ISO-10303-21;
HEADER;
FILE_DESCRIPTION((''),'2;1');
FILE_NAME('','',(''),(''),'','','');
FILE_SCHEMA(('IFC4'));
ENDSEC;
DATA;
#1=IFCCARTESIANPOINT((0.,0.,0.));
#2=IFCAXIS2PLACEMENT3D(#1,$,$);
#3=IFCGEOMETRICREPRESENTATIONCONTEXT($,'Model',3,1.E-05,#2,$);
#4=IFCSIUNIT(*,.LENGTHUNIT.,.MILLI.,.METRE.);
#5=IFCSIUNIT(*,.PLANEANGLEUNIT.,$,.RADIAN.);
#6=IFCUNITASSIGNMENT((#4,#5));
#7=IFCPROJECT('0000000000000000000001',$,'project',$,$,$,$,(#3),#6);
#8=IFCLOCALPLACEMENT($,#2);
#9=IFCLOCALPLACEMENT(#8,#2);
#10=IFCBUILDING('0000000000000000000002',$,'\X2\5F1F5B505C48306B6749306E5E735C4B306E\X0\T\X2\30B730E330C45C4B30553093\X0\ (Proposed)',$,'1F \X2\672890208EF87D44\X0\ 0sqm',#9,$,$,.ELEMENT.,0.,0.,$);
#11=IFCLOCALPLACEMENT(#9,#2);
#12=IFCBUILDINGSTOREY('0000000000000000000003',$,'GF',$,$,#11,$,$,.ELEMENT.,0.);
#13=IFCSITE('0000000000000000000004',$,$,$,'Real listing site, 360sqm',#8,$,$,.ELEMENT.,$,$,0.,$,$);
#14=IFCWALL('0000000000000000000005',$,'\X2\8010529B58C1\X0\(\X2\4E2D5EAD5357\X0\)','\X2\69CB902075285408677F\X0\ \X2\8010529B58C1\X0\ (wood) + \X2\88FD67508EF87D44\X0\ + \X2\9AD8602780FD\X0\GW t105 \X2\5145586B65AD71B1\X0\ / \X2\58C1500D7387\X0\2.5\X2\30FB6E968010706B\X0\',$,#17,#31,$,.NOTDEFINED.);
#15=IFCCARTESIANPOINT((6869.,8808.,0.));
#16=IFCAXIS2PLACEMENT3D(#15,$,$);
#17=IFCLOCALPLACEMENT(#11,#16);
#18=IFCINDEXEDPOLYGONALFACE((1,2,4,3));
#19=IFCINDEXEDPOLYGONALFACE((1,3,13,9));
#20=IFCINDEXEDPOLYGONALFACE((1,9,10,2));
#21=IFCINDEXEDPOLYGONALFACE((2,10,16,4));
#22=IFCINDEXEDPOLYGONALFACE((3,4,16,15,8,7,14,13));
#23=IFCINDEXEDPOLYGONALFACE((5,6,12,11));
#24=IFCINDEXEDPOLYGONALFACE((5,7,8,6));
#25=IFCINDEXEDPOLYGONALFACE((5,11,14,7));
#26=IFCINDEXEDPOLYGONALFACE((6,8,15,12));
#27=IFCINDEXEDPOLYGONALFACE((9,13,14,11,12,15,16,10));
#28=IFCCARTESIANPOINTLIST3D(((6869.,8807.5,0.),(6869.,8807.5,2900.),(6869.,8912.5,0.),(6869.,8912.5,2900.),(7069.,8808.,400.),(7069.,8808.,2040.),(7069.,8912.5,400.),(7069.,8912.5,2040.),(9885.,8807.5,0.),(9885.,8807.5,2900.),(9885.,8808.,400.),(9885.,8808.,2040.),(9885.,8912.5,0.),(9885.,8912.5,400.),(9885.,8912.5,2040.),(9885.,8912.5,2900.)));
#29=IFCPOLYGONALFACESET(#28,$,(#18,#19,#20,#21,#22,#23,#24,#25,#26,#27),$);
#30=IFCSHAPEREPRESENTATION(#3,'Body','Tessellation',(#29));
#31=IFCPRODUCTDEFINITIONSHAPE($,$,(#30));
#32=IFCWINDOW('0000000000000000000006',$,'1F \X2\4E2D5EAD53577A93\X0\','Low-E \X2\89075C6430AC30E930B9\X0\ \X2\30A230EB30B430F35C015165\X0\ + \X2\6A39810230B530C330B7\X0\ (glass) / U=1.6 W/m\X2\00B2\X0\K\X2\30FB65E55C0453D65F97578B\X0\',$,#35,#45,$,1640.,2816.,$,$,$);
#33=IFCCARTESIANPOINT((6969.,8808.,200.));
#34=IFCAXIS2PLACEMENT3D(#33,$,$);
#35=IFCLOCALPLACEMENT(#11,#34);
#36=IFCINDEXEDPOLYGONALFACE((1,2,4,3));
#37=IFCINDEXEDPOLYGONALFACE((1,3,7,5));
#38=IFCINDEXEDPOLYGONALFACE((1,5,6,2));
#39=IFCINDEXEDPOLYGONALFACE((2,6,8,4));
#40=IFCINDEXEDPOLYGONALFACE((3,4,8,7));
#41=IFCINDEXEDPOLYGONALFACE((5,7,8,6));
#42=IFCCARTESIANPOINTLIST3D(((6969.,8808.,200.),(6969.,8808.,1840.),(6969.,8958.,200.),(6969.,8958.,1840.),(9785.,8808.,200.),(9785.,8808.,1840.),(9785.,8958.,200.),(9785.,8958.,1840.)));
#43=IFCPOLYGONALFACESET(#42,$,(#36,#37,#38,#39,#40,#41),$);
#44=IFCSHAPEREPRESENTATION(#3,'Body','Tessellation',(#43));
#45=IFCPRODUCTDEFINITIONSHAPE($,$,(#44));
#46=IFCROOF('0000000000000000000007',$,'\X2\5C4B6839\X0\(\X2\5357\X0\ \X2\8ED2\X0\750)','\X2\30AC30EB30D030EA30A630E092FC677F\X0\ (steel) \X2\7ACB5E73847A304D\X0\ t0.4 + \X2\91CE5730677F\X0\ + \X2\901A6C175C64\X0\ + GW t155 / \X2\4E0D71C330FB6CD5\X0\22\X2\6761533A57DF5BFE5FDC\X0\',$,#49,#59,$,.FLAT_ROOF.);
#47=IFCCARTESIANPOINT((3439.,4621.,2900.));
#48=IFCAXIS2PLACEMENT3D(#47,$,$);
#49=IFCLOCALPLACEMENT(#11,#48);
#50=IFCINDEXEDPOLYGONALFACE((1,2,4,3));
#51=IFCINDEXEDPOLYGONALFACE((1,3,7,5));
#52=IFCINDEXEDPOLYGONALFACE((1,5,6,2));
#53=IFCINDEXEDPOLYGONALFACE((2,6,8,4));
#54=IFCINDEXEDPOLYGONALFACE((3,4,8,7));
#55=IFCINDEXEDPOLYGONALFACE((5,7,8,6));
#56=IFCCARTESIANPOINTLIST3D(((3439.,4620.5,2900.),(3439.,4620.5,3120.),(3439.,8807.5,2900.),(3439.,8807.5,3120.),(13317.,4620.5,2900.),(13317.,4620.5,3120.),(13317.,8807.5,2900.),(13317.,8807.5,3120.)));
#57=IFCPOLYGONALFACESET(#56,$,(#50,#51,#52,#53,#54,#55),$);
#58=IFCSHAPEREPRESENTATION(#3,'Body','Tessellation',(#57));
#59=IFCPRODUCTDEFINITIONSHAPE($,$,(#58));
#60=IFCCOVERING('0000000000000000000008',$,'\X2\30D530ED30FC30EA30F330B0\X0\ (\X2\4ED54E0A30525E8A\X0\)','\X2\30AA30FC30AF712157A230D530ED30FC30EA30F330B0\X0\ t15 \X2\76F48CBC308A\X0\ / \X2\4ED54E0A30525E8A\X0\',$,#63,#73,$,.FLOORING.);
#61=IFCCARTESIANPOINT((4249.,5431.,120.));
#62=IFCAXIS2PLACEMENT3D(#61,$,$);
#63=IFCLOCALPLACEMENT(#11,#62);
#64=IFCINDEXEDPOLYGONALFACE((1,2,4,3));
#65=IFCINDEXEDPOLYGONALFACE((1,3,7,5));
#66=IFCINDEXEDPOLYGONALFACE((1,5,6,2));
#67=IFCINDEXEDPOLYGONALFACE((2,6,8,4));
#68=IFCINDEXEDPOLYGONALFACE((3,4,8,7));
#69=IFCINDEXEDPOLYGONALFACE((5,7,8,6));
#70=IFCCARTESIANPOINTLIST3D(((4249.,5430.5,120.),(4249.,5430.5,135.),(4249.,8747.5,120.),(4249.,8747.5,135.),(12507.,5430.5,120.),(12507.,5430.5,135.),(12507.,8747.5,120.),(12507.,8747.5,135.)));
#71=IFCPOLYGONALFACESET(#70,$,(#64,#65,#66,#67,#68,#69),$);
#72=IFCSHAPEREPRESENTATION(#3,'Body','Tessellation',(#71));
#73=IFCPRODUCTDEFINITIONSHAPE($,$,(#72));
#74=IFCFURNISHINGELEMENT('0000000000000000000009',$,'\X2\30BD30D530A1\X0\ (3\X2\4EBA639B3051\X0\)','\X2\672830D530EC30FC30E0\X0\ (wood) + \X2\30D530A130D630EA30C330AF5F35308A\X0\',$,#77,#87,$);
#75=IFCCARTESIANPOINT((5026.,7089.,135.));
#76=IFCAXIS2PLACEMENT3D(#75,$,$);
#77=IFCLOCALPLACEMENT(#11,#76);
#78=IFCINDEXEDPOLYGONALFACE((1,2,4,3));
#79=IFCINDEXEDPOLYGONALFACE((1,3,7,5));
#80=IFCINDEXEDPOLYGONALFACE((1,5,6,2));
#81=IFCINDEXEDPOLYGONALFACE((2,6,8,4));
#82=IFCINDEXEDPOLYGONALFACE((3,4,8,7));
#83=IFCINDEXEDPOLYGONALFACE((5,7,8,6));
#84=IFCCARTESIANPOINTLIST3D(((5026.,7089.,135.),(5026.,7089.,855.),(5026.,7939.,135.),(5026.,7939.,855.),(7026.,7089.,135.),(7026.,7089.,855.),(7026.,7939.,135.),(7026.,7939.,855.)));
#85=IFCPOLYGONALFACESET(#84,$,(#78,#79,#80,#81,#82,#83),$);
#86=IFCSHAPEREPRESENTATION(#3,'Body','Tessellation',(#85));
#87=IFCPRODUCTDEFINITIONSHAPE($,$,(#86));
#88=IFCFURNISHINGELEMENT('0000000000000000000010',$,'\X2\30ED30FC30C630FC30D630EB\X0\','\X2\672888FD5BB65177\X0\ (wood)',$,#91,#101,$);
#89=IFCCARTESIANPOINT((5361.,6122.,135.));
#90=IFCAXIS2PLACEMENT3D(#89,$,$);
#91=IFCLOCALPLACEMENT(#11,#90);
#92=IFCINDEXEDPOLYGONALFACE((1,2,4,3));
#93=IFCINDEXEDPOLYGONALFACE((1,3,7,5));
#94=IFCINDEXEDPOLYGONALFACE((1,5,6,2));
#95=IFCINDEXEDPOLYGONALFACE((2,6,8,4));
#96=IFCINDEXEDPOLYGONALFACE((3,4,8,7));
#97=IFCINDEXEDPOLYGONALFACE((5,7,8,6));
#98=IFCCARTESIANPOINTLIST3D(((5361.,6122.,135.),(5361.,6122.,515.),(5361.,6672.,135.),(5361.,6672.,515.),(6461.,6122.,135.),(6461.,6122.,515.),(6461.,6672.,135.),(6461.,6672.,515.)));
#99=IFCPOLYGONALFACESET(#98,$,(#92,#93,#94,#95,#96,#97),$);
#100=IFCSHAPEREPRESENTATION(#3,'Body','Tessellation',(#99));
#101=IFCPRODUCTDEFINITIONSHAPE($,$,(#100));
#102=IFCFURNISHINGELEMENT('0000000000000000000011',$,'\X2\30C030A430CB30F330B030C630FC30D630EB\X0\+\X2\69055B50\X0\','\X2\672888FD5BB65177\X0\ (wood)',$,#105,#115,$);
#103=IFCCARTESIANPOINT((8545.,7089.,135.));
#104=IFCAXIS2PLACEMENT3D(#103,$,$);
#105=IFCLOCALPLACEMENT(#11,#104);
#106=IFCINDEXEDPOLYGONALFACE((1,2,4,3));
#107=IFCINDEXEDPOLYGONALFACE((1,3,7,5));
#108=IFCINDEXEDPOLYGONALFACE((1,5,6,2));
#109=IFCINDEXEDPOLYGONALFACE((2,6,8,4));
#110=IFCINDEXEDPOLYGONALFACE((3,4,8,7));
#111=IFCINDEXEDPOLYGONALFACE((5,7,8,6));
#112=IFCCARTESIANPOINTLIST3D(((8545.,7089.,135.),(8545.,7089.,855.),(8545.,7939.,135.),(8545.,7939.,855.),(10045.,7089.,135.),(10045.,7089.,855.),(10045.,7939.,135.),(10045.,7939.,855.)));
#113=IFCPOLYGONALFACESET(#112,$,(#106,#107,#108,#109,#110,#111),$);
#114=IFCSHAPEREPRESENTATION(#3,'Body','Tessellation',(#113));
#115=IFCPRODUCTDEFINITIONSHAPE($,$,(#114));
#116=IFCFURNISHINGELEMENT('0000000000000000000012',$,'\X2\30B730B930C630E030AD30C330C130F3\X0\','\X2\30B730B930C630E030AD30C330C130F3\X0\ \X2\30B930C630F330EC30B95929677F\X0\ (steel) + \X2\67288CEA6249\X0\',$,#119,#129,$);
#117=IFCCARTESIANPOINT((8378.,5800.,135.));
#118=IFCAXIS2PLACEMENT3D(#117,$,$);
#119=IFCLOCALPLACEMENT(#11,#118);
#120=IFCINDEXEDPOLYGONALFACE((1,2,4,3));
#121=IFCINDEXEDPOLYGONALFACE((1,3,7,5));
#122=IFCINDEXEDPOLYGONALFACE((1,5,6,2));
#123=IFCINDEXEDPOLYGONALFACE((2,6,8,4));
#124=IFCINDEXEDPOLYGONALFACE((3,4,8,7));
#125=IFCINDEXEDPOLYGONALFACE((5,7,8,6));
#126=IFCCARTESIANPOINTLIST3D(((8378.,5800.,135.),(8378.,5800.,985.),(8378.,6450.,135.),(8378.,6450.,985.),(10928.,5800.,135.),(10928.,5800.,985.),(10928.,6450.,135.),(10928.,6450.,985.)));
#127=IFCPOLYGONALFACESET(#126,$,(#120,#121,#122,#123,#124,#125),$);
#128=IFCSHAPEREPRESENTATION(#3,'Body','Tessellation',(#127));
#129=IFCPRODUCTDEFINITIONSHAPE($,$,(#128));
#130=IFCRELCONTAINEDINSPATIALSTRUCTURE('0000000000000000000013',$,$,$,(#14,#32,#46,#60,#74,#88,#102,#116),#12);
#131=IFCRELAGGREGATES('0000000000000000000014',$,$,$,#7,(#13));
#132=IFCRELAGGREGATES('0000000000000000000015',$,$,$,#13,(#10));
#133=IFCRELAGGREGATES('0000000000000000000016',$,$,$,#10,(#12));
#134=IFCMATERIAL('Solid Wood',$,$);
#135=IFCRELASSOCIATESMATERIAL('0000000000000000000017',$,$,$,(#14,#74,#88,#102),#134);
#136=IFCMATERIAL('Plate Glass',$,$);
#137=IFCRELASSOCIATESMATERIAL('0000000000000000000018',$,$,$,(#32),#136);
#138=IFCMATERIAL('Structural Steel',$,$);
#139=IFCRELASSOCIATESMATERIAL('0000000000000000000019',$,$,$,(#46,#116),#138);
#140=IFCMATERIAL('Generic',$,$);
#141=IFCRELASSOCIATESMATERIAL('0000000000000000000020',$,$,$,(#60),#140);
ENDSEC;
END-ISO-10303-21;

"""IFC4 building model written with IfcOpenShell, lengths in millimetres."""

from ifc_helpers import new_model, si_unit, frame, frame_2d, origin, place, context, project, spatial, rectangle, extrude, material, element, fill, save


model = new_model("IFC4")

# Units and contexts
model_context = context("Model", 3, precision=1e-05, world=origin())
ifc_project = project(units=[si_unit("LENGTHUNIT", "METRE", prefix="MILLI"), si_unit("PLANEANGLEUNIT", "RADIAN")], contexts=[model_context])

# Site, building, storey
site_placement = place(None, origin())
site = spatial("IfcSite", under=ifc_project, at=site_placement, ObjectType="Real listing site, 360sqm", CompositionType="ELEMENT", RefElevation=0.0)
building_placement = place(site_placement, origin())
building = spatial("IfcBuilding", under=site, at=building_placement, Name="弟子屈に杉の平屋のTシャツ屋さん (Proposed)", ObjectType="1F 木造軸組 0sqm", CompositionType="ELEMENT", ElevationOfRefHeight=0.0, ElevationOfTerrain=0.0)
storey_placement = place(building_placement, origin())
storey = spatial("IfcBuildingStorey", under=building, at=storey_placement, Name="GF", CompositionType="ELEMENT", Elevation=0.0)

# Shared definitions
ifc_material_1 = material(Name="Solid Wood")

# Shared definitions
ifc_material_2 = material(Name="Plate Glass")

# Wall, opening, window
wall_1_placement = place(storey_placement, frame((6869.0, 8808.0, 0.0)))
wall_1 = element("IfcWall", 1, at=wall_1_placement, inside=storey, material=ifc_material_1, Name="耐力壁(中庭南)", Description="構造用合板 耐力壁 (wood) + 製材軸組 + 高性能GW t105 充填断熱 / 壁倍率2.5・準耐火", PredefinedType="NOTDEFINED", context=model_context, shape_type="SweptSolid", body=[
    extrude(rectangle(XDim=3016.0, YDim=105.0, at=frame_2d((1508.0, 52.0))), frame((6869.0, 8808.0, 0.0)), (0.0, 0.0, 1.0), 2900.0),
])
opening_1_placement = place(storey_placement, frame((6969.0, 8808.0, 200.0)))
opening_1 = element("IfcOpeningElement", 2, at=opening_1_placement, cuts=wall_1, PredefinedType="NOTDEFINED", context=model_context, shape_type="SweptSolid", body=[
    extrude(rectangle(XDim=2816.0, YDim=150.0, at=frame_2d((1408.0, 75.0))), frame((6969.0, 8808.0, 200.0)), (0.0, 0.0, 1.0), 1640.0),
])
window_1_placement = place(storey_placement, frame((6969.0, 8808.0, 200.0)))
window_1 = element("IfcWindow", 3, at=window_1_placement, inside=storey, material=ifc_material_2, Name="1F 中庭南窓", Description="Low-E 複層ガラス アルゴン封入 + 樹脂サッシ (glass) / U=1.6 W/m²K・日射取得型", OverallHeight=1640.0, OverallWidth=2816.0, context=model_context, shape_type="SweptSolid", body=[
    extrude(rectangle(XDim=2816.0, YDim=150.0, at=frame_2d((1408.0, 75.0))), frame((6969.0, 8808.0, 200.0)), (0.0, 0.0, 1.0), 1640.0),
])
fill(opening_1, window_1)

# Roof
ifc_material_3 = material(Name="Structural Steel")
roof_placement = place(storey_placement, frame((3439.0, 4621.0, 2900.0)))
element("IfcRoof", 4, at=roof_placement, inside=storey, material=ifc_material_3, Name="屋根(南 軒750)", Description="ガルバリウム鋼板 (steel) 立平葺き t0.4 + 野地板 + 通気層 + GW t155 / 不燃・法22条区域対応", PredefinedType="FLAT_ROOF", context=model_context, shape_type="SweptSolid", body=[
    extrude(rectangle(XDim=9878.0, YDim=4187.0, at=frame_2d((4939.0, 2093.0))), frame((3439.0, 4621.0, 2900.0)), (0.0, 0.0, 1.0), 220.0),
])

# Covering
ifc_material_4 = material(Name="Generic")
covering_placement = place(storey_placement, frame((4249.0, 5431.0, 120.0)))
element("IfcCovering", 5, at=covering_placement, inside=storey, material=ifc_material_4, Name="フローリング (仕上げ床)", Description="オーク無垢フローリング t15 直貼り / 仕上げ床", PredefinedType="FLOORING", context=model_context, shape_type="SweptSolid", body=[
    extrude(rectangle(XDim=8258.0, YDim=3317.0, at=frame_2d((4129.0, 1658.0))), frame((4249.0, 5431.0, 120.0)), (0.0, 0.0, 1.0), 15.0),
])

# Furnishing elements
furnishing_1_placement = place(storey_placement, frame((5026.0, 7089.0, 135.0)))
element("IfcFurnishingElement", 6, at=furnishing_1_placement, inside=storey, material=ifc_material_1, Name="ソファ (3人掛け)", Description="木フレーム (wood) + ファブリック張り", context=model_context, shape_type="SweptSolid", body=[
    extrude(rectangle(XDim=2000.0, YDim=850.0, at=frame_2d((1000.0, 425.0))), frame((5026.0, 7089.0, 135.0)), (0.0, 0.0, 1.0), 720.0),
])
furnishing_2_placement = place(storey_placement, frame((5361.0, 6122.0, 135.0)))
element("IfcFurnishingElement", 7, at=furnishing_2_placement, inside=storey, material=ifc_material_1, Name="ローテーブル", Description="木製家具 (wood)", context=model_context, shape_type="SweptSolid", body=[
    extrude(rectangle(XDim=1100.0, YDim=550.0, at=frame_2d((550.0, 275.0))), frame((5361.0, 6122.0, 135.0)), (0.0, 0.0, 1.0), 380.0),
])
furnishing_3_placement = place(storey_placement, frame((8545.0, 7089.0, 135.0)))
element("IfcFurnishingElement", 8, at=furnishing_3_placement, inside=storey, material=ifc_material_1, Name="ダイニングテーブル+椅子", Description="木製家具 (wood)", context=model_context, shape_type="SweptSolid", body=[
    extrude(rectangle(XDim=1500.0, YDim=850.0, at=frame_2d((750.0, 425.0))), frame((8545.0, 7089.0, 135.0)), (0.0, 0.0, 1.0), 720.0),
])
furnishing_4_placement = place(storey_placement, frame((8378.0, 5800.0, 135.0)))
element("IfcFurnishingElement", 9, at=furnishing_4_placement, inside=storey, material=ifc_material_3, Name="システムキッチン", Description="システムキッチン ステンレス天板 (steel) + 木質扉", context=model_context, shape_type="SweptSolid", body=[
    extrude(rectangle(XDim=2550.0, YDim=650.0, at=frame_2d((1275.0, 325.0))), frame((8378.0, 5800.0, 135.0)), (0.0, 0.0, 1.0), 850.0),
])

save(model, "model.ifc")
